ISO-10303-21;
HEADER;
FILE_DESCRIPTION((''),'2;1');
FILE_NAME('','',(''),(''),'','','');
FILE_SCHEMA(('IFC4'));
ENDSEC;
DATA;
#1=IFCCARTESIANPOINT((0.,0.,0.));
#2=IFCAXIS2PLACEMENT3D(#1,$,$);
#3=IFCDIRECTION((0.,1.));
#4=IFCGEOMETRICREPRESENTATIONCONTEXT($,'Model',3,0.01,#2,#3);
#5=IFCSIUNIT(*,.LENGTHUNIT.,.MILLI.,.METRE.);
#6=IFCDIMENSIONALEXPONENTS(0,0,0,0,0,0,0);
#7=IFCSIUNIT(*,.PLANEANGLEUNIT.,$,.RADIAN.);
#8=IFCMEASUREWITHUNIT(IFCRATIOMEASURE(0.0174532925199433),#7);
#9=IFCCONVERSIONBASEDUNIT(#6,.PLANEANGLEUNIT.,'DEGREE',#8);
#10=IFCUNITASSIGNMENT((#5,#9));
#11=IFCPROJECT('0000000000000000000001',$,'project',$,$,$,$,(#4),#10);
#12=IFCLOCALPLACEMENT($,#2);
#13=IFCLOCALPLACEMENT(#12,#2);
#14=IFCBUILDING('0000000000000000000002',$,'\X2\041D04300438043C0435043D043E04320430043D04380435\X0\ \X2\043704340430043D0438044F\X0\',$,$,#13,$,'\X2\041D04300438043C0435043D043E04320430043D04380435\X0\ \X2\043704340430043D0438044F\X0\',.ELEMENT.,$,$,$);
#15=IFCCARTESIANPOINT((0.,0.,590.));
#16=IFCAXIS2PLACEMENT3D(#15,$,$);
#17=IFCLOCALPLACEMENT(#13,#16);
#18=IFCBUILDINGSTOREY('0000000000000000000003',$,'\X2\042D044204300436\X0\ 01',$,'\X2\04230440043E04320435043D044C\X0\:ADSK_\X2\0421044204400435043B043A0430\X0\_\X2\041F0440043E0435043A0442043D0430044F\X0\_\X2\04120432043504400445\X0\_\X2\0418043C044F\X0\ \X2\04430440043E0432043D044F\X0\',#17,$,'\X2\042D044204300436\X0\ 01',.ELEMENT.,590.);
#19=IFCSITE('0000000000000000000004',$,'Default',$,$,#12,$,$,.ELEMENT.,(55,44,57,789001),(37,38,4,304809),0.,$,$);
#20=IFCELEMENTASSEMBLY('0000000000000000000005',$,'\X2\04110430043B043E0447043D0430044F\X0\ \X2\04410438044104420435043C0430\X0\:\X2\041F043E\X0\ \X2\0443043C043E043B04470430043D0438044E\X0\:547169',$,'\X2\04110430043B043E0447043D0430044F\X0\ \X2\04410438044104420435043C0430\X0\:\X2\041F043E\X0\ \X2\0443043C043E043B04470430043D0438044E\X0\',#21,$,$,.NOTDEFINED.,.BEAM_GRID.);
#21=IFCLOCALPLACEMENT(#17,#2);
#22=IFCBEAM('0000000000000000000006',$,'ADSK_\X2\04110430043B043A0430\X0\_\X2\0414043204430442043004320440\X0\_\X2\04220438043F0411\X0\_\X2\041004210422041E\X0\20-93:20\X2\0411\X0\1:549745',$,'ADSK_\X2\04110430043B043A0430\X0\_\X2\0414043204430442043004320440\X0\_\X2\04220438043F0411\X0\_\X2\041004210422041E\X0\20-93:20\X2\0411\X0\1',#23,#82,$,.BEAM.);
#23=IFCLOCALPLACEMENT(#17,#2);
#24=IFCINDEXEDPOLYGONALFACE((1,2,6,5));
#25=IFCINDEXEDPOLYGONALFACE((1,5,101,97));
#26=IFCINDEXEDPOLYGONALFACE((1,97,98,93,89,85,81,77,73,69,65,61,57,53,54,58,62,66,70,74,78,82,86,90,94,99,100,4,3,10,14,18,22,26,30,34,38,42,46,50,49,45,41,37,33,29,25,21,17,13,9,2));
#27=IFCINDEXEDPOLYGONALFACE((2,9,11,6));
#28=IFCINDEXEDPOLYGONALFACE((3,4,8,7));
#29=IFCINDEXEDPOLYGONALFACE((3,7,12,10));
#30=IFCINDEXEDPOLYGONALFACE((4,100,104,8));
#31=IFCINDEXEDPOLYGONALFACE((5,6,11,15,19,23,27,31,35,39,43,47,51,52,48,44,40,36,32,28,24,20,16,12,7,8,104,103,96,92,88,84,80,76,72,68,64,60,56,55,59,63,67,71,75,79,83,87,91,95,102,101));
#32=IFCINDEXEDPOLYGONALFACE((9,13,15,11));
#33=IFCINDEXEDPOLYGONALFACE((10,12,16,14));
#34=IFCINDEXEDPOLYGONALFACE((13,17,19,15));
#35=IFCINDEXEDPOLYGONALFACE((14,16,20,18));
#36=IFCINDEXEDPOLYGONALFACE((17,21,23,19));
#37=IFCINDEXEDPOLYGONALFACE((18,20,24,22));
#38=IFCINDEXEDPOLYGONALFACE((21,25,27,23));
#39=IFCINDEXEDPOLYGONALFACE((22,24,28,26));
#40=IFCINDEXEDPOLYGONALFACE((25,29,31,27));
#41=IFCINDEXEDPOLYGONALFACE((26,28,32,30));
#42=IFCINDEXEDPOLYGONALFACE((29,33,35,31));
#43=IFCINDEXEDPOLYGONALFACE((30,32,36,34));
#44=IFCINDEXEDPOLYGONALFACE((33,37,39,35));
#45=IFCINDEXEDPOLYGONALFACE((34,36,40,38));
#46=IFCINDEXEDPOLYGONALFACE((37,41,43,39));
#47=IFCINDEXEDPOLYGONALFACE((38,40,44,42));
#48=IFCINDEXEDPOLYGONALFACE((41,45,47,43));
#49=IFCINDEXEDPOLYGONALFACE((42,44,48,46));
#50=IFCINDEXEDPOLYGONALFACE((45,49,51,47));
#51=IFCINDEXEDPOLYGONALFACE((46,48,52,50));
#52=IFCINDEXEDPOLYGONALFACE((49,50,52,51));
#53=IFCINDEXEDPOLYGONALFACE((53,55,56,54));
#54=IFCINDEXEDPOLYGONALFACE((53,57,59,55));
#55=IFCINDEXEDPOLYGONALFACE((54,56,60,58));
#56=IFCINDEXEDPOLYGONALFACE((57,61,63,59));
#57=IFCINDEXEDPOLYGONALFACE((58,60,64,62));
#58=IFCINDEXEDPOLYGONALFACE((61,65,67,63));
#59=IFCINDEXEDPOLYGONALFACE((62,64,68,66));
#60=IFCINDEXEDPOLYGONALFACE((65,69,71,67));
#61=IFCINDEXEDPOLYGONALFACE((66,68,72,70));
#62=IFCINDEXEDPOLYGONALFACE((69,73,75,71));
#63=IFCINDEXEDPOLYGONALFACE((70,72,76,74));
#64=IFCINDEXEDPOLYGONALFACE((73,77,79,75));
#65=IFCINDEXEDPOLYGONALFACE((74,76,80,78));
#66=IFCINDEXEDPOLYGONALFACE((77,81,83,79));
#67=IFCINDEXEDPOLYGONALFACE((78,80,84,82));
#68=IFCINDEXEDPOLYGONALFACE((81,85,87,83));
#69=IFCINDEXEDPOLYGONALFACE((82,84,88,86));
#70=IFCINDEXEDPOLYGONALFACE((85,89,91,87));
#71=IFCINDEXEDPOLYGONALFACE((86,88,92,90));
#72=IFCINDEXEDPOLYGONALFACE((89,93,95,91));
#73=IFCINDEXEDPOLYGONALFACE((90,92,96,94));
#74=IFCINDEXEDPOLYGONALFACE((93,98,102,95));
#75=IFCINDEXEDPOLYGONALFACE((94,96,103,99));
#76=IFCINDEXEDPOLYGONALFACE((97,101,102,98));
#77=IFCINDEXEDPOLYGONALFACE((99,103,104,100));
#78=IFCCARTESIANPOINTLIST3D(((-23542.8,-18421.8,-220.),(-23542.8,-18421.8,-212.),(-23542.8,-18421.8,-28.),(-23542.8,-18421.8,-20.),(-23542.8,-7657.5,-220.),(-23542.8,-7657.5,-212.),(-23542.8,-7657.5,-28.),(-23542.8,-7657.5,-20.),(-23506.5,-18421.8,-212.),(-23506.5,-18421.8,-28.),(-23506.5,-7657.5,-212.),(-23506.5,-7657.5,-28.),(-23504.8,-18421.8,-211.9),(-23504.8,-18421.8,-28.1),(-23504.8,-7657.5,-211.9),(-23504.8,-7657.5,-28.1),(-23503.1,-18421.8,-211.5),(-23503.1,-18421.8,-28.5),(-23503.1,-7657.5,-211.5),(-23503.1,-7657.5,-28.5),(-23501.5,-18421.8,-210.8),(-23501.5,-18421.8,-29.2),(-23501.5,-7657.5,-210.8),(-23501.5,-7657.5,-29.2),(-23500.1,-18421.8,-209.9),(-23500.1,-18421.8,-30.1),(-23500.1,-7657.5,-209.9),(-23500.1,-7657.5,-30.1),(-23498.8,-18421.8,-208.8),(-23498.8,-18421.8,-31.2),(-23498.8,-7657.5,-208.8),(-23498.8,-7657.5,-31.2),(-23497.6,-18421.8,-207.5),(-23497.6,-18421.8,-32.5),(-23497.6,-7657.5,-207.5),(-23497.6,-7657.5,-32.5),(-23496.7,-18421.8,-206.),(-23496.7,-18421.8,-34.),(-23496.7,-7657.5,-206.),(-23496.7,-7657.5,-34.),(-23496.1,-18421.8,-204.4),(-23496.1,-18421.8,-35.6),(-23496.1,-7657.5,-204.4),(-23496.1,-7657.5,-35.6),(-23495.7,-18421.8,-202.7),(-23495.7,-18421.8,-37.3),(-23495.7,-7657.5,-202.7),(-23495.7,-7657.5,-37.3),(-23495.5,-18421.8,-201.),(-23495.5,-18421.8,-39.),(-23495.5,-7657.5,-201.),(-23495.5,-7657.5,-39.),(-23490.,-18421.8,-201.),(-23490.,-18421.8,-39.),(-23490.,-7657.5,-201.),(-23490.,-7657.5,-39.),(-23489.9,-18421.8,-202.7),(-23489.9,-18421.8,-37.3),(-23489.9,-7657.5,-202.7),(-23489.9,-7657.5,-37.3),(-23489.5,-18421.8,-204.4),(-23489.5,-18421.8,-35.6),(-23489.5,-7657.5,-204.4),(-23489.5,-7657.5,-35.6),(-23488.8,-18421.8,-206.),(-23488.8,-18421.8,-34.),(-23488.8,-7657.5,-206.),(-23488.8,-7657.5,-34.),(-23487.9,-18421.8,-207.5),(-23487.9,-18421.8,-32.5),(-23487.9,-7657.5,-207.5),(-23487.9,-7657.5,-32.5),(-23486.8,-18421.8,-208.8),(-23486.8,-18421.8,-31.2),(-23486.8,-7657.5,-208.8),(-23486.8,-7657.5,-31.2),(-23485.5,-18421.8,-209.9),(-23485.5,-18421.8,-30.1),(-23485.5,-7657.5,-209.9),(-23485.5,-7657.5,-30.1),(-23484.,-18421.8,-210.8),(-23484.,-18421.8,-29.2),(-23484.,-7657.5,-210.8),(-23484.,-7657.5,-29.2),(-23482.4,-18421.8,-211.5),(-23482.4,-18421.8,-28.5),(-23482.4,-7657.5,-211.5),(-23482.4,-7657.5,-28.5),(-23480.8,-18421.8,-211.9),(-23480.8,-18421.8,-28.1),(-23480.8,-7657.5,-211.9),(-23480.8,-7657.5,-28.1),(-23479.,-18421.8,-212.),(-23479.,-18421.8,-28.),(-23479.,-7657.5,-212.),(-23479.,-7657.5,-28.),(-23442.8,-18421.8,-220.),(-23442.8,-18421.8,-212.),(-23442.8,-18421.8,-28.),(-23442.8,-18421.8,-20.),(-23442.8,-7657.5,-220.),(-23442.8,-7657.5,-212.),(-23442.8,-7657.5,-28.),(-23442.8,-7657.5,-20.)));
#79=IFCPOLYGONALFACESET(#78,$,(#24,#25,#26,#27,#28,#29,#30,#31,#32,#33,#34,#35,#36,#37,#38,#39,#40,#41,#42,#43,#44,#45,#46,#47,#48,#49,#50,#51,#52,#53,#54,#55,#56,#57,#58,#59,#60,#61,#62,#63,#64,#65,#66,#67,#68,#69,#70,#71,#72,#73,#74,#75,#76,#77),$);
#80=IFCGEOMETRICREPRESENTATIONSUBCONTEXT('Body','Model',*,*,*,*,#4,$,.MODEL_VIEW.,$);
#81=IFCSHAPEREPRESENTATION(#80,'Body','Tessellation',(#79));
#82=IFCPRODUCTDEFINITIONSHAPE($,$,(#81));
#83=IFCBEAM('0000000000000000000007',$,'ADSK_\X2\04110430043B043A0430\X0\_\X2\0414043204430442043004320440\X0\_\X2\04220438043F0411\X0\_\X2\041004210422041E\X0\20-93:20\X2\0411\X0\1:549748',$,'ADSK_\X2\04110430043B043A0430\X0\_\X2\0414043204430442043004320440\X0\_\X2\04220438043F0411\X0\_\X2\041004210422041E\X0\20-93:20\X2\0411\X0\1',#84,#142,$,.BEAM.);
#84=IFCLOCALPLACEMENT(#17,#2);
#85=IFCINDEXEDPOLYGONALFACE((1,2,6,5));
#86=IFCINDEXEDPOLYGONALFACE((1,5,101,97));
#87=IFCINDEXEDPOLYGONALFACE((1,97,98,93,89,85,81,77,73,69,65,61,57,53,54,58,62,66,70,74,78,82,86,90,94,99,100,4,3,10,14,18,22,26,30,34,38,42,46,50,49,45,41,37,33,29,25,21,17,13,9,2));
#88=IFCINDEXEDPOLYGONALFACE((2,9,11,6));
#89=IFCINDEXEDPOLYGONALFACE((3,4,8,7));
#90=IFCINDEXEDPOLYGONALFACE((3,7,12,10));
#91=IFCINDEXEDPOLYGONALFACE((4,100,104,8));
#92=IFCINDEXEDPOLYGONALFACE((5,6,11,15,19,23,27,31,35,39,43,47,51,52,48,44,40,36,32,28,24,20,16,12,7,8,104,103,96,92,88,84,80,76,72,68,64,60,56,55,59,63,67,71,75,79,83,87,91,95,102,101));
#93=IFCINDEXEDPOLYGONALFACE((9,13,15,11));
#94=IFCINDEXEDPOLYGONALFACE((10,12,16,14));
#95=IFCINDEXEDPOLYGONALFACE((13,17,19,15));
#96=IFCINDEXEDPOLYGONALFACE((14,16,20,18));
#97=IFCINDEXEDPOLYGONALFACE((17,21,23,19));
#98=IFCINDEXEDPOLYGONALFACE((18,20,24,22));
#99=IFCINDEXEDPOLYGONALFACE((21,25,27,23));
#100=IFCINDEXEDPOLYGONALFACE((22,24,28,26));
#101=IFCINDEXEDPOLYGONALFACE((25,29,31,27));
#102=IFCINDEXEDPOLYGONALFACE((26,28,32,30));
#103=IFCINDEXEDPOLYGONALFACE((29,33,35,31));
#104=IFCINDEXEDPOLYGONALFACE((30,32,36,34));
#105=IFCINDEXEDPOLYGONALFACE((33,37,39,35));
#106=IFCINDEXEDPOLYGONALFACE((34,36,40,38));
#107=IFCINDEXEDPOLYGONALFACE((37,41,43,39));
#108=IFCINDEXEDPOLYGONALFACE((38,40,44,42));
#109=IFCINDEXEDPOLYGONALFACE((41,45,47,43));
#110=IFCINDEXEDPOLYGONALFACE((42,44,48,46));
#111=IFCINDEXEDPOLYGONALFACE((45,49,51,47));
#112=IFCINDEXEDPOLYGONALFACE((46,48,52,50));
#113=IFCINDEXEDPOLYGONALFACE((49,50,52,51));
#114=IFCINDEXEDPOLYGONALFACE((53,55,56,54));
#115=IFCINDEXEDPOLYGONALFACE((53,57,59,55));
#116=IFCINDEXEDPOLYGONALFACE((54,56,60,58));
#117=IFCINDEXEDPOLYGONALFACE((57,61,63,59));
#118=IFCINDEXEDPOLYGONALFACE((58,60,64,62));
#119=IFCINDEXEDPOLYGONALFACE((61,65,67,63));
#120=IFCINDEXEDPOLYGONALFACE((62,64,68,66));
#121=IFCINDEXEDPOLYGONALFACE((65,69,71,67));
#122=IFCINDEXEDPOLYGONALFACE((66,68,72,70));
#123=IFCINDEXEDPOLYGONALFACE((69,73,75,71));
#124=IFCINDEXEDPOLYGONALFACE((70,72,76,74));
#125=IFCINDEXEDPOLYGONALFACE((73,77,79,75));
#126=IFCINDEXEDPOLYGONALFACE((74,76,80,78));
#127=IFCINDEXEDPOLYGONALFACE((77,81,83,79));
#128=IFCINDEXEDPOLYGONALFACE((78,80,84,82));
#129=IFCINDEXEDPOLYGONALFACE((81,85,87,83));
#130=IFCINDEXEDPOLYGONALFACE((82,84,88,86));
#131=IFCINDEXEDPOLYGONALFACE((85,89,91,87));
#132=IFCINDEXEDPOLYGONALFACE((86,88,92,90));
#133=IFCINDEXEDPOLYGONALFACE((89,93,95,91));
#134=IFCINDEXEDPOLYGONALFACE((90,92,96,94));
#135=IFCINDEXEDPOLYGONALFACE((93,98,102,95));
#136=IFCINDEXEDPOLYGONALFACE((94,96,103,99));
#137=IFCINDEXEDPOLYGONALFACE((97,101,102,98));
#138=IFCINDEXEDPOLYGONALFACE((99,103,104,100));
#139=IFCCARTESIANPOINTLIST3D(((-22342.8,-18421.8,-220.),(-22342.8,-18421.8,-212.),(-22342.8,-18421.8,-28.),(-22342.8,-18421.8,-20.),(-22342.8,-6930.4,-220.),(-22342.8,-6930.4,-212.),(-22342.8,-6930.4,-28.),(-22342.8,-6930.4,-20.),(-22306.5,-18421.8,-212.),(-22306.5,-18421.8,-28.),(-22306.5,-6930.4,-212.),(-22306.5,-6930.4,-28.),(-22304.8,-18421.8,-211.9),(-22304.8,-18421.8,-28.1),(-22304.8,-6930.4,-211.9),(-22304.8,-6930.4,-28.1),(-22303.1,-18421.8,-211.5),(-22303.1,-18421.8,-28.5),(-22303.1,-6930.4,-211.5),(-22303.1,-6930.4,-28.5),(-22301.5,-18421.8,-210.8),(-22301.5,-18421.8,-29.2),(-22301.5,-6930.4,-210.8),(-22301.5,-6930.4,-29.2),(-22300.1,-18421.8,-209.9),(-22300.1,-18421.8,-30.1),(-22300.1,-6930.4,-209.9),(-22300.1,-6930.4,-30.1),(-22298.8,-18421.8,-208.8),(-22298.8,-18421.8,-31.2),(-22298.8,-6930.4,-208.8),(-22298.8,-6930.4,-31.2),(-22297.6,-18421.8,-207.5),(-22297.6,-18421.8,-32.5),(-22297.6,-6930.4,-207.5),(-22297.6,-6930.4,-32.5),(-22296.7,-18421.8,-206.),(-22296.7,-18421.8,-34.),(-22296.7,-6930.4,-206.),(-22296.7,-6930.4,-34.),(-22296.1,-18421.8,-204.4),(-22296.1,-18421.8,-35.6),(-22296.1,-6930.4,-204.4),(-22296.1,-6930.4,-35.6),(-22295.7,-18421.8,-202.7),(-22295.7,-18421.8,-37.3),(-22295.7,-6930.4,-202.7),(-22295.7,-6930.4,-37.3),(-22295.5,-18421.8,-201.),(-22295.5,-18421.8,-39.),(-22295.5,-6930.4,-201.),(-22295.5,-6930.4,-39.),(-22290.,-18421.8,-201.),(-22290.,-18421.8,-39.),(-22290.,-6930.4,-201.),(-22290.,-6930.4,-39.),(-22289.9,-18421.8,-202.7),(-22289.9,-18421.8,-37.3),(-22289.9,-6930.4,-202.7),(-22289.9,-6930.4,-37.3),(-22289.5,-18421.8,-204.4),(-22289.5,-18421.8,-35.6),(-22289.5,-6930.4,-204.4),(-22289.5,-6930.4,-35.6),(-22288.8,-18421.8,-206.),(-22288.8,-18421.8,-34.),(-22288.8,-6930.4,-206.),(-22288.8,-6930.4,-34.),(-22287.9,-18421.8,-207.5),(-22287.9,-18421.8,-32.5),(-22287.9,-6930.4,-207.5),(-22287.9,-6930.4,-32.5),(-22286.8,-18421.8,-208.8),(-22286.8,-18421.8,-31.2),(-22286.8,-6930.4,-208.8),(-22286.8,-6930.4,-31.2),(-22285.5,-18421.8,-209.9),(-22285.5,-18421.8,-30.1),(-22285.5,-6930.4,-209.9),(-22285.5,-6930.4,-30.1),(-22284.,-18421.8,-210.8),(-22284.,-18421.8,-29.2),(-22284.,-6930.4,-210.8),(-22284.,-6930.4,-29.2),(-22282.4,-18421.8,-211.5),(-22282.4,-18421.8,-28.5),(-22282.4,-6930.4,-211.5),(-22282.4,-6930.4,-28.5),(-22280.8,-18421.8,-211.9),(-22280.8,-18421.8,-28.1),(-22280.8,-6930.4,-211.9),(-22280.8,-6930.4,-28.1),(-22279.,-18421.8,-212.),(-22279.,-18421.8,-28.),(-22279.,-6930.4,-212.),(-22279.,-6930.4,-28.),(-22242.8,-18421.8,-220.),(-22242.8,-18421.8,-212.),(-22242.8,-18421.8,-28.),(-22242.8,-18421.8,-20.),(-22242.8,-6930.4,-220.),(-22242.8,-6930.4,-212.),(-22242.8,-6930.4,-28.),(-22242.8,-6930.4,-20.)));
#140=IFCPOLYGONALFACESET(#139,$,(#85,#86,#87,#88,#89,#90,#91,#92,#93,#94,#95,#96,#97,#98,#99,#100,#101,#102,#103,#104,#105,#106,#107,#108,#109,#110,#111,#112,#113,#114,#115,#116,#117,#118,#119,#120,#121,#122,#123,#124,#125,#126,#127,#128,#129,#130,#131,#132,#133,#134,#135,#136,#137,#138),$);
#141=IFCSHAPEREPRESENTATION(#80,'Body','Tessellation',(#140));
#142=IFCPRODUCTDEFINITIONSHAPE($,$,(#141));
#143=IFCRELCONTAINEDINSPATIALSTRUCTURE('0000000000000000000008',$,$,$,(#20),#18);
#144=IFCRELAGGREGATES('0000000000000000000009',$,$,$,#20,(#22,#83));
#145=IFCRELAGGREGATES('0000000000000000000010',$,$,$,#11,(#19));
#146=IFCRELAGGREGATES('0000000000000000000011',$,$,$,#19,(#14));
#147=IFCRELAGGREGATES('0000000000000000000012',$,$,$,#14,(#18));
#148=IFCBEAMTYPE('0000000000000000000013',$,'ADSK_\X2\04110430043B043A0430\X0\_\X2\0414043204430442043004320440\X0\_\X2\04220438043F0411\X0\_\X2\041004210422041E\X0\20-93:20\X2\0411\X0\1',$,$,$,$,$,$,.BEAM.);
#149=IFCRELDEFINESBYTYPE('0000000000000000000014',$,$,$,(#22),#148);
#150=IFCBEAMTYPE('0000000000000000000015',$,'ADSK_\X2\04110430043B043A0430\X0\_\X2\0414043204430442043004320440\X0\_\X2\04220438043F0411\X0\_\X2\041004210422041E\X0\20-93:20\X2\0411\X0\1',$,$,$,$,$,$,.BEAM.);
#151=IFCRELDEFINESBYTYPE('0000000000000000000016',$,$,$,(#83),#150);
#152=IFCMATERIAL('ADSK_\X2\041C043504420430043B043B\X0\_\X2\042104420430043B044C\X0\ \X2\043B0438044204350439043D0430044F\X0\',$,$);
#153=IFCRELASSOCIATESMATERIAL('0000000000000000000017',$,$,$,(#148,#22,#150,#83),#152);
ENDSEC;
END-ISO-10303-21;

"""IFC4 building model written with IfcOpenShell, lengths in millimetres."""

from ifc_helpers import new_model, entity, si_unit, converted_unit, direction, frame, origin, place, context, subcontext, project, spatial, indexed_curve, outline, extrude, source, transform, mapped, material, type_object, type_shapes, element, aggregate, save


model = new_model("IFC4")

# Units and contexts
model_context = context("Model", 3, precision=0.01, world=origin(), true_north=direction((0.0, 1.0)))
body_context = subcontext(model_context, "Body", "Model", "MODEL_VIEW")
ifc_project = project(units=[si_unit("LENGTHUNIT", "METRE", prefix="MILLI"), converted_unit("PLANEANGLEUNIT", "DEGREE", entity("IfcRatioMeasure", 0.0174532925199433), si_unit("PLANEANGLEUNIT", "RADIAN"), dimensions=[0, 0, 0, 0, 0, 0, 0])], contexts=[model_context])

# Site, building, storey
site_placement = place(None, origin())
site = spatial("IfcSite", under=ifc_project, at=site_placement, Name="Default", CompositionType="ELEMENT", RefLatitude=(55, 44, 57, 789001), RefLongitude=(37, 38, 4, 304809), RefElevation=0.0)
building_placement = place(site_placement, origin())
building = spatial("IfcBuilding", under=site, at=building_placement, Name="Наименование здания", LongName="Наименование здания", CompositionType="ELEMENT")
storey_placement = place(building_placement, frame((0.0, 0.0, 590.0)))
storey = spatial("IfcBuildingStorey", under=building, at=storey_placement, Name="Этаж 01", ObjectType="Уровень:ADSK_Стрелка_Проектная_Вверх_Имя уровня", LongName="Этаж 01", CompositionType="ELEMENT", Elevation=590.0)

# Element assembly, beams
assembly_placement = place(storey_placement, origin())
assembly = element("IfcElementAssembly", 1, at=assembly_placement, inside=storey, Name="Балочная система:По умолчанию:547169", ObjectType="Балочная система:По умолчанию", AssemblyPlace="NOTDEFINED", PredefinedType="BEAM_GRID")
ifc_material_1 = material(Name="ADSK_Металл_Сталь литейная")
beam_type_1 = type_object("IfcBeamType", Name="ADSK_Балка_Двутавр_ТипБ_АСТО20-93:20Б1", PredefinedType="BEAM", material=ifc_material_1)
shared_shape_1 = source(origin(), body_context, "Body", "SweptSolid", [
    extrude(outline(indexed_curve([(-100.0, -50.0), (-92.0, -50.0), (-92.0, -13.8), (-91.9, -12.0), (-91.5, -10.4), (-90.8, -8.8), (-89.9, -7.3), (-88.8, -6.0), (-87.5, -4.9), (-86.0, -3.9), (-84.4, -3.3), (-82.7, -2.9), (-81.0, -2.8), (81.0, -2.8), (82.7, -2.9), (84.4, -3.3), (86.0, -3.9), (87.5, -4.9), (88.8, -6.0), (89.9, -7.3), (90.8, -8.8), (91.5, -10.4), (91.9, -12.0), (92.0, -13.7), (92.0, -50.0), (100.0, -50.0), (100.0, 50.0), (92.0, 50.0), (92.0, 13.8), (91.9, 12.0), (91.5, 10.4), (90.8, 8.8), (89.9, 7.3), (88.8, 6.0), (87.5, 4.9), (86.0, 3.9), (84.4, 3.3), (82.7, 2.9), (81.0, 2.8), (-81.0, 2.8), (-82.7, 2.9), (-84.4, 3.3), (-86.0, 3.9), (-87.5, 4.9), (-88.8, 6.0), (-89.9, 7.3), (-90.8, 8.8), (-91.5, 10.4), (-91.9, 12.0), (-92.0, 13.8), (-92.0, 50.0), (-100.0, 50.0), (-100.0, -50.0)], self_intersect=False)), frame((-5382.1, 0.0, -100.0), z_axis=(1.0, 0.0, 0.0), x_axis=(0.0, 0.0, -1.0)), (0.0, 0.0, 1.0), 10764.3),
])
type_shapes(beam_type_1, [shared_shape_1])
beam_1_placement = place(assembly_placement, frame((-23492.8, -13039.7, -20.0), z_axis=(0.0, 0.0, 1.0), x_axis=(0.0, 1.0, 0.0)))
beam_1 = element("IfcBeam", 2, at=beam_1_placement, type_object=beam_type_1, material=ifc_material_1, Name="ADSK_Балка_Двутавр_ТипБ_АСТО20-93:20Б1:549745", ObjectType="ADSK_Балка_Двутавр_ТипБ_АСТО20-93:20Б1", PredefinedType="BEAM", context=body_context, shape_type="MappedRepresentation", body=[
    mapped(shared_shape_1, transform((0.0, 0.0, 0.0), scale=1.0)),
])
beam_type_2 = type_object("IfcBeamType", Name="ADSK_Балка_Двутавр_ТипБ_АСТО20-93:20Б1", PredefinedType="BEAM", material=ifc_material_1)
shared_shape_2 = source(origin(), body_context, "Body", "SweptSolid", [
    extrude(outline(indexed_curve([(-100.0, -50.0), (-92.0, -50.0), (-92.0, -13.8), (-91.9, -12.0), (-91.5, -10.4), (-90.8, -8.8), (-89.9, -7.3), (-88.8, -6.0), (-87.5, -4.9), (-86.0, -3.9), (-84.4, -3.3), (-82.7, -2.9), (-81.0, -2.8), (81.0, -2.8), (82.7, -2.9), (84.4, -3.3), (86.0, -3.9), (87.5, -4.9), (88.8, -6.0), (89.9, -7.3), (90.8, -8.8), (91.5, -10.4), (91.9, -12.0), (92.0, -13.7), (92.0, -50.0), (100.0, -50.0), (100.0, 50.0), (92.0, 50.0), (92.0, 13.8), (91.9, 12.0), (91.5, 10.4), (90.8, 8.8), (89.9, 7.3), (88.8, 6.0), (87.5, 4.9), (86.0, 3.9), (84.4, 3.3), (82.7, 2.9), (81.0, 2.8), (-81.0, 2.8), (-82.7, 2.9), (-84.4, 3.3), (-86.0, 3.9), (-87.5, 4.9), (-88.8, 6.0), (-89.9, 7.3), (-90.8, 8.8), (-91.5, 10.4), (-91.9, 12.0), (-92.0, 13.8), (-92.0, 50.0), (-100.0, 50.0), (-100.0, -50.0)], self_intersect=False)), frame((-5745.7, 0.0, -100.0), z_axis=(1.0, 0.0, 0.0), x_axis=(0.0, 0.0, -1.0)), (0.0, 0.0, 1.0), 11491.4),
])
type_shapes(beam_type_2, [shared_shape_2])
beam_2_placement = place(assembly_placement, frame((-22292.8, -12676.1, -20.0), z_axis=(0.0, 0.0, 1.0), x_axis=(0.0, 1.0, 0.0)))
beam_2 = element("IfcBeam", 3, at=beam_2_placement, type_object=beam_type_2, material=ifc_material_1, Name="ADSK_Балка_Двутавр_ТипБ_АСТО20-93:20Б1:549748", ObjectType="ADSK_Балка_Двутавр_ТипБ_АСТО20-93:20Б1", PredefinedType="BEAM", context=body_context, shape_type="MappedRepresentation", body=[
    mapped(shared_shape_2, transform((0.0, 0.0, 0.0), scale=1.0)),
])
aggregate(assembly, [beam_1, beam_2])

save(model, "model.ifc")
